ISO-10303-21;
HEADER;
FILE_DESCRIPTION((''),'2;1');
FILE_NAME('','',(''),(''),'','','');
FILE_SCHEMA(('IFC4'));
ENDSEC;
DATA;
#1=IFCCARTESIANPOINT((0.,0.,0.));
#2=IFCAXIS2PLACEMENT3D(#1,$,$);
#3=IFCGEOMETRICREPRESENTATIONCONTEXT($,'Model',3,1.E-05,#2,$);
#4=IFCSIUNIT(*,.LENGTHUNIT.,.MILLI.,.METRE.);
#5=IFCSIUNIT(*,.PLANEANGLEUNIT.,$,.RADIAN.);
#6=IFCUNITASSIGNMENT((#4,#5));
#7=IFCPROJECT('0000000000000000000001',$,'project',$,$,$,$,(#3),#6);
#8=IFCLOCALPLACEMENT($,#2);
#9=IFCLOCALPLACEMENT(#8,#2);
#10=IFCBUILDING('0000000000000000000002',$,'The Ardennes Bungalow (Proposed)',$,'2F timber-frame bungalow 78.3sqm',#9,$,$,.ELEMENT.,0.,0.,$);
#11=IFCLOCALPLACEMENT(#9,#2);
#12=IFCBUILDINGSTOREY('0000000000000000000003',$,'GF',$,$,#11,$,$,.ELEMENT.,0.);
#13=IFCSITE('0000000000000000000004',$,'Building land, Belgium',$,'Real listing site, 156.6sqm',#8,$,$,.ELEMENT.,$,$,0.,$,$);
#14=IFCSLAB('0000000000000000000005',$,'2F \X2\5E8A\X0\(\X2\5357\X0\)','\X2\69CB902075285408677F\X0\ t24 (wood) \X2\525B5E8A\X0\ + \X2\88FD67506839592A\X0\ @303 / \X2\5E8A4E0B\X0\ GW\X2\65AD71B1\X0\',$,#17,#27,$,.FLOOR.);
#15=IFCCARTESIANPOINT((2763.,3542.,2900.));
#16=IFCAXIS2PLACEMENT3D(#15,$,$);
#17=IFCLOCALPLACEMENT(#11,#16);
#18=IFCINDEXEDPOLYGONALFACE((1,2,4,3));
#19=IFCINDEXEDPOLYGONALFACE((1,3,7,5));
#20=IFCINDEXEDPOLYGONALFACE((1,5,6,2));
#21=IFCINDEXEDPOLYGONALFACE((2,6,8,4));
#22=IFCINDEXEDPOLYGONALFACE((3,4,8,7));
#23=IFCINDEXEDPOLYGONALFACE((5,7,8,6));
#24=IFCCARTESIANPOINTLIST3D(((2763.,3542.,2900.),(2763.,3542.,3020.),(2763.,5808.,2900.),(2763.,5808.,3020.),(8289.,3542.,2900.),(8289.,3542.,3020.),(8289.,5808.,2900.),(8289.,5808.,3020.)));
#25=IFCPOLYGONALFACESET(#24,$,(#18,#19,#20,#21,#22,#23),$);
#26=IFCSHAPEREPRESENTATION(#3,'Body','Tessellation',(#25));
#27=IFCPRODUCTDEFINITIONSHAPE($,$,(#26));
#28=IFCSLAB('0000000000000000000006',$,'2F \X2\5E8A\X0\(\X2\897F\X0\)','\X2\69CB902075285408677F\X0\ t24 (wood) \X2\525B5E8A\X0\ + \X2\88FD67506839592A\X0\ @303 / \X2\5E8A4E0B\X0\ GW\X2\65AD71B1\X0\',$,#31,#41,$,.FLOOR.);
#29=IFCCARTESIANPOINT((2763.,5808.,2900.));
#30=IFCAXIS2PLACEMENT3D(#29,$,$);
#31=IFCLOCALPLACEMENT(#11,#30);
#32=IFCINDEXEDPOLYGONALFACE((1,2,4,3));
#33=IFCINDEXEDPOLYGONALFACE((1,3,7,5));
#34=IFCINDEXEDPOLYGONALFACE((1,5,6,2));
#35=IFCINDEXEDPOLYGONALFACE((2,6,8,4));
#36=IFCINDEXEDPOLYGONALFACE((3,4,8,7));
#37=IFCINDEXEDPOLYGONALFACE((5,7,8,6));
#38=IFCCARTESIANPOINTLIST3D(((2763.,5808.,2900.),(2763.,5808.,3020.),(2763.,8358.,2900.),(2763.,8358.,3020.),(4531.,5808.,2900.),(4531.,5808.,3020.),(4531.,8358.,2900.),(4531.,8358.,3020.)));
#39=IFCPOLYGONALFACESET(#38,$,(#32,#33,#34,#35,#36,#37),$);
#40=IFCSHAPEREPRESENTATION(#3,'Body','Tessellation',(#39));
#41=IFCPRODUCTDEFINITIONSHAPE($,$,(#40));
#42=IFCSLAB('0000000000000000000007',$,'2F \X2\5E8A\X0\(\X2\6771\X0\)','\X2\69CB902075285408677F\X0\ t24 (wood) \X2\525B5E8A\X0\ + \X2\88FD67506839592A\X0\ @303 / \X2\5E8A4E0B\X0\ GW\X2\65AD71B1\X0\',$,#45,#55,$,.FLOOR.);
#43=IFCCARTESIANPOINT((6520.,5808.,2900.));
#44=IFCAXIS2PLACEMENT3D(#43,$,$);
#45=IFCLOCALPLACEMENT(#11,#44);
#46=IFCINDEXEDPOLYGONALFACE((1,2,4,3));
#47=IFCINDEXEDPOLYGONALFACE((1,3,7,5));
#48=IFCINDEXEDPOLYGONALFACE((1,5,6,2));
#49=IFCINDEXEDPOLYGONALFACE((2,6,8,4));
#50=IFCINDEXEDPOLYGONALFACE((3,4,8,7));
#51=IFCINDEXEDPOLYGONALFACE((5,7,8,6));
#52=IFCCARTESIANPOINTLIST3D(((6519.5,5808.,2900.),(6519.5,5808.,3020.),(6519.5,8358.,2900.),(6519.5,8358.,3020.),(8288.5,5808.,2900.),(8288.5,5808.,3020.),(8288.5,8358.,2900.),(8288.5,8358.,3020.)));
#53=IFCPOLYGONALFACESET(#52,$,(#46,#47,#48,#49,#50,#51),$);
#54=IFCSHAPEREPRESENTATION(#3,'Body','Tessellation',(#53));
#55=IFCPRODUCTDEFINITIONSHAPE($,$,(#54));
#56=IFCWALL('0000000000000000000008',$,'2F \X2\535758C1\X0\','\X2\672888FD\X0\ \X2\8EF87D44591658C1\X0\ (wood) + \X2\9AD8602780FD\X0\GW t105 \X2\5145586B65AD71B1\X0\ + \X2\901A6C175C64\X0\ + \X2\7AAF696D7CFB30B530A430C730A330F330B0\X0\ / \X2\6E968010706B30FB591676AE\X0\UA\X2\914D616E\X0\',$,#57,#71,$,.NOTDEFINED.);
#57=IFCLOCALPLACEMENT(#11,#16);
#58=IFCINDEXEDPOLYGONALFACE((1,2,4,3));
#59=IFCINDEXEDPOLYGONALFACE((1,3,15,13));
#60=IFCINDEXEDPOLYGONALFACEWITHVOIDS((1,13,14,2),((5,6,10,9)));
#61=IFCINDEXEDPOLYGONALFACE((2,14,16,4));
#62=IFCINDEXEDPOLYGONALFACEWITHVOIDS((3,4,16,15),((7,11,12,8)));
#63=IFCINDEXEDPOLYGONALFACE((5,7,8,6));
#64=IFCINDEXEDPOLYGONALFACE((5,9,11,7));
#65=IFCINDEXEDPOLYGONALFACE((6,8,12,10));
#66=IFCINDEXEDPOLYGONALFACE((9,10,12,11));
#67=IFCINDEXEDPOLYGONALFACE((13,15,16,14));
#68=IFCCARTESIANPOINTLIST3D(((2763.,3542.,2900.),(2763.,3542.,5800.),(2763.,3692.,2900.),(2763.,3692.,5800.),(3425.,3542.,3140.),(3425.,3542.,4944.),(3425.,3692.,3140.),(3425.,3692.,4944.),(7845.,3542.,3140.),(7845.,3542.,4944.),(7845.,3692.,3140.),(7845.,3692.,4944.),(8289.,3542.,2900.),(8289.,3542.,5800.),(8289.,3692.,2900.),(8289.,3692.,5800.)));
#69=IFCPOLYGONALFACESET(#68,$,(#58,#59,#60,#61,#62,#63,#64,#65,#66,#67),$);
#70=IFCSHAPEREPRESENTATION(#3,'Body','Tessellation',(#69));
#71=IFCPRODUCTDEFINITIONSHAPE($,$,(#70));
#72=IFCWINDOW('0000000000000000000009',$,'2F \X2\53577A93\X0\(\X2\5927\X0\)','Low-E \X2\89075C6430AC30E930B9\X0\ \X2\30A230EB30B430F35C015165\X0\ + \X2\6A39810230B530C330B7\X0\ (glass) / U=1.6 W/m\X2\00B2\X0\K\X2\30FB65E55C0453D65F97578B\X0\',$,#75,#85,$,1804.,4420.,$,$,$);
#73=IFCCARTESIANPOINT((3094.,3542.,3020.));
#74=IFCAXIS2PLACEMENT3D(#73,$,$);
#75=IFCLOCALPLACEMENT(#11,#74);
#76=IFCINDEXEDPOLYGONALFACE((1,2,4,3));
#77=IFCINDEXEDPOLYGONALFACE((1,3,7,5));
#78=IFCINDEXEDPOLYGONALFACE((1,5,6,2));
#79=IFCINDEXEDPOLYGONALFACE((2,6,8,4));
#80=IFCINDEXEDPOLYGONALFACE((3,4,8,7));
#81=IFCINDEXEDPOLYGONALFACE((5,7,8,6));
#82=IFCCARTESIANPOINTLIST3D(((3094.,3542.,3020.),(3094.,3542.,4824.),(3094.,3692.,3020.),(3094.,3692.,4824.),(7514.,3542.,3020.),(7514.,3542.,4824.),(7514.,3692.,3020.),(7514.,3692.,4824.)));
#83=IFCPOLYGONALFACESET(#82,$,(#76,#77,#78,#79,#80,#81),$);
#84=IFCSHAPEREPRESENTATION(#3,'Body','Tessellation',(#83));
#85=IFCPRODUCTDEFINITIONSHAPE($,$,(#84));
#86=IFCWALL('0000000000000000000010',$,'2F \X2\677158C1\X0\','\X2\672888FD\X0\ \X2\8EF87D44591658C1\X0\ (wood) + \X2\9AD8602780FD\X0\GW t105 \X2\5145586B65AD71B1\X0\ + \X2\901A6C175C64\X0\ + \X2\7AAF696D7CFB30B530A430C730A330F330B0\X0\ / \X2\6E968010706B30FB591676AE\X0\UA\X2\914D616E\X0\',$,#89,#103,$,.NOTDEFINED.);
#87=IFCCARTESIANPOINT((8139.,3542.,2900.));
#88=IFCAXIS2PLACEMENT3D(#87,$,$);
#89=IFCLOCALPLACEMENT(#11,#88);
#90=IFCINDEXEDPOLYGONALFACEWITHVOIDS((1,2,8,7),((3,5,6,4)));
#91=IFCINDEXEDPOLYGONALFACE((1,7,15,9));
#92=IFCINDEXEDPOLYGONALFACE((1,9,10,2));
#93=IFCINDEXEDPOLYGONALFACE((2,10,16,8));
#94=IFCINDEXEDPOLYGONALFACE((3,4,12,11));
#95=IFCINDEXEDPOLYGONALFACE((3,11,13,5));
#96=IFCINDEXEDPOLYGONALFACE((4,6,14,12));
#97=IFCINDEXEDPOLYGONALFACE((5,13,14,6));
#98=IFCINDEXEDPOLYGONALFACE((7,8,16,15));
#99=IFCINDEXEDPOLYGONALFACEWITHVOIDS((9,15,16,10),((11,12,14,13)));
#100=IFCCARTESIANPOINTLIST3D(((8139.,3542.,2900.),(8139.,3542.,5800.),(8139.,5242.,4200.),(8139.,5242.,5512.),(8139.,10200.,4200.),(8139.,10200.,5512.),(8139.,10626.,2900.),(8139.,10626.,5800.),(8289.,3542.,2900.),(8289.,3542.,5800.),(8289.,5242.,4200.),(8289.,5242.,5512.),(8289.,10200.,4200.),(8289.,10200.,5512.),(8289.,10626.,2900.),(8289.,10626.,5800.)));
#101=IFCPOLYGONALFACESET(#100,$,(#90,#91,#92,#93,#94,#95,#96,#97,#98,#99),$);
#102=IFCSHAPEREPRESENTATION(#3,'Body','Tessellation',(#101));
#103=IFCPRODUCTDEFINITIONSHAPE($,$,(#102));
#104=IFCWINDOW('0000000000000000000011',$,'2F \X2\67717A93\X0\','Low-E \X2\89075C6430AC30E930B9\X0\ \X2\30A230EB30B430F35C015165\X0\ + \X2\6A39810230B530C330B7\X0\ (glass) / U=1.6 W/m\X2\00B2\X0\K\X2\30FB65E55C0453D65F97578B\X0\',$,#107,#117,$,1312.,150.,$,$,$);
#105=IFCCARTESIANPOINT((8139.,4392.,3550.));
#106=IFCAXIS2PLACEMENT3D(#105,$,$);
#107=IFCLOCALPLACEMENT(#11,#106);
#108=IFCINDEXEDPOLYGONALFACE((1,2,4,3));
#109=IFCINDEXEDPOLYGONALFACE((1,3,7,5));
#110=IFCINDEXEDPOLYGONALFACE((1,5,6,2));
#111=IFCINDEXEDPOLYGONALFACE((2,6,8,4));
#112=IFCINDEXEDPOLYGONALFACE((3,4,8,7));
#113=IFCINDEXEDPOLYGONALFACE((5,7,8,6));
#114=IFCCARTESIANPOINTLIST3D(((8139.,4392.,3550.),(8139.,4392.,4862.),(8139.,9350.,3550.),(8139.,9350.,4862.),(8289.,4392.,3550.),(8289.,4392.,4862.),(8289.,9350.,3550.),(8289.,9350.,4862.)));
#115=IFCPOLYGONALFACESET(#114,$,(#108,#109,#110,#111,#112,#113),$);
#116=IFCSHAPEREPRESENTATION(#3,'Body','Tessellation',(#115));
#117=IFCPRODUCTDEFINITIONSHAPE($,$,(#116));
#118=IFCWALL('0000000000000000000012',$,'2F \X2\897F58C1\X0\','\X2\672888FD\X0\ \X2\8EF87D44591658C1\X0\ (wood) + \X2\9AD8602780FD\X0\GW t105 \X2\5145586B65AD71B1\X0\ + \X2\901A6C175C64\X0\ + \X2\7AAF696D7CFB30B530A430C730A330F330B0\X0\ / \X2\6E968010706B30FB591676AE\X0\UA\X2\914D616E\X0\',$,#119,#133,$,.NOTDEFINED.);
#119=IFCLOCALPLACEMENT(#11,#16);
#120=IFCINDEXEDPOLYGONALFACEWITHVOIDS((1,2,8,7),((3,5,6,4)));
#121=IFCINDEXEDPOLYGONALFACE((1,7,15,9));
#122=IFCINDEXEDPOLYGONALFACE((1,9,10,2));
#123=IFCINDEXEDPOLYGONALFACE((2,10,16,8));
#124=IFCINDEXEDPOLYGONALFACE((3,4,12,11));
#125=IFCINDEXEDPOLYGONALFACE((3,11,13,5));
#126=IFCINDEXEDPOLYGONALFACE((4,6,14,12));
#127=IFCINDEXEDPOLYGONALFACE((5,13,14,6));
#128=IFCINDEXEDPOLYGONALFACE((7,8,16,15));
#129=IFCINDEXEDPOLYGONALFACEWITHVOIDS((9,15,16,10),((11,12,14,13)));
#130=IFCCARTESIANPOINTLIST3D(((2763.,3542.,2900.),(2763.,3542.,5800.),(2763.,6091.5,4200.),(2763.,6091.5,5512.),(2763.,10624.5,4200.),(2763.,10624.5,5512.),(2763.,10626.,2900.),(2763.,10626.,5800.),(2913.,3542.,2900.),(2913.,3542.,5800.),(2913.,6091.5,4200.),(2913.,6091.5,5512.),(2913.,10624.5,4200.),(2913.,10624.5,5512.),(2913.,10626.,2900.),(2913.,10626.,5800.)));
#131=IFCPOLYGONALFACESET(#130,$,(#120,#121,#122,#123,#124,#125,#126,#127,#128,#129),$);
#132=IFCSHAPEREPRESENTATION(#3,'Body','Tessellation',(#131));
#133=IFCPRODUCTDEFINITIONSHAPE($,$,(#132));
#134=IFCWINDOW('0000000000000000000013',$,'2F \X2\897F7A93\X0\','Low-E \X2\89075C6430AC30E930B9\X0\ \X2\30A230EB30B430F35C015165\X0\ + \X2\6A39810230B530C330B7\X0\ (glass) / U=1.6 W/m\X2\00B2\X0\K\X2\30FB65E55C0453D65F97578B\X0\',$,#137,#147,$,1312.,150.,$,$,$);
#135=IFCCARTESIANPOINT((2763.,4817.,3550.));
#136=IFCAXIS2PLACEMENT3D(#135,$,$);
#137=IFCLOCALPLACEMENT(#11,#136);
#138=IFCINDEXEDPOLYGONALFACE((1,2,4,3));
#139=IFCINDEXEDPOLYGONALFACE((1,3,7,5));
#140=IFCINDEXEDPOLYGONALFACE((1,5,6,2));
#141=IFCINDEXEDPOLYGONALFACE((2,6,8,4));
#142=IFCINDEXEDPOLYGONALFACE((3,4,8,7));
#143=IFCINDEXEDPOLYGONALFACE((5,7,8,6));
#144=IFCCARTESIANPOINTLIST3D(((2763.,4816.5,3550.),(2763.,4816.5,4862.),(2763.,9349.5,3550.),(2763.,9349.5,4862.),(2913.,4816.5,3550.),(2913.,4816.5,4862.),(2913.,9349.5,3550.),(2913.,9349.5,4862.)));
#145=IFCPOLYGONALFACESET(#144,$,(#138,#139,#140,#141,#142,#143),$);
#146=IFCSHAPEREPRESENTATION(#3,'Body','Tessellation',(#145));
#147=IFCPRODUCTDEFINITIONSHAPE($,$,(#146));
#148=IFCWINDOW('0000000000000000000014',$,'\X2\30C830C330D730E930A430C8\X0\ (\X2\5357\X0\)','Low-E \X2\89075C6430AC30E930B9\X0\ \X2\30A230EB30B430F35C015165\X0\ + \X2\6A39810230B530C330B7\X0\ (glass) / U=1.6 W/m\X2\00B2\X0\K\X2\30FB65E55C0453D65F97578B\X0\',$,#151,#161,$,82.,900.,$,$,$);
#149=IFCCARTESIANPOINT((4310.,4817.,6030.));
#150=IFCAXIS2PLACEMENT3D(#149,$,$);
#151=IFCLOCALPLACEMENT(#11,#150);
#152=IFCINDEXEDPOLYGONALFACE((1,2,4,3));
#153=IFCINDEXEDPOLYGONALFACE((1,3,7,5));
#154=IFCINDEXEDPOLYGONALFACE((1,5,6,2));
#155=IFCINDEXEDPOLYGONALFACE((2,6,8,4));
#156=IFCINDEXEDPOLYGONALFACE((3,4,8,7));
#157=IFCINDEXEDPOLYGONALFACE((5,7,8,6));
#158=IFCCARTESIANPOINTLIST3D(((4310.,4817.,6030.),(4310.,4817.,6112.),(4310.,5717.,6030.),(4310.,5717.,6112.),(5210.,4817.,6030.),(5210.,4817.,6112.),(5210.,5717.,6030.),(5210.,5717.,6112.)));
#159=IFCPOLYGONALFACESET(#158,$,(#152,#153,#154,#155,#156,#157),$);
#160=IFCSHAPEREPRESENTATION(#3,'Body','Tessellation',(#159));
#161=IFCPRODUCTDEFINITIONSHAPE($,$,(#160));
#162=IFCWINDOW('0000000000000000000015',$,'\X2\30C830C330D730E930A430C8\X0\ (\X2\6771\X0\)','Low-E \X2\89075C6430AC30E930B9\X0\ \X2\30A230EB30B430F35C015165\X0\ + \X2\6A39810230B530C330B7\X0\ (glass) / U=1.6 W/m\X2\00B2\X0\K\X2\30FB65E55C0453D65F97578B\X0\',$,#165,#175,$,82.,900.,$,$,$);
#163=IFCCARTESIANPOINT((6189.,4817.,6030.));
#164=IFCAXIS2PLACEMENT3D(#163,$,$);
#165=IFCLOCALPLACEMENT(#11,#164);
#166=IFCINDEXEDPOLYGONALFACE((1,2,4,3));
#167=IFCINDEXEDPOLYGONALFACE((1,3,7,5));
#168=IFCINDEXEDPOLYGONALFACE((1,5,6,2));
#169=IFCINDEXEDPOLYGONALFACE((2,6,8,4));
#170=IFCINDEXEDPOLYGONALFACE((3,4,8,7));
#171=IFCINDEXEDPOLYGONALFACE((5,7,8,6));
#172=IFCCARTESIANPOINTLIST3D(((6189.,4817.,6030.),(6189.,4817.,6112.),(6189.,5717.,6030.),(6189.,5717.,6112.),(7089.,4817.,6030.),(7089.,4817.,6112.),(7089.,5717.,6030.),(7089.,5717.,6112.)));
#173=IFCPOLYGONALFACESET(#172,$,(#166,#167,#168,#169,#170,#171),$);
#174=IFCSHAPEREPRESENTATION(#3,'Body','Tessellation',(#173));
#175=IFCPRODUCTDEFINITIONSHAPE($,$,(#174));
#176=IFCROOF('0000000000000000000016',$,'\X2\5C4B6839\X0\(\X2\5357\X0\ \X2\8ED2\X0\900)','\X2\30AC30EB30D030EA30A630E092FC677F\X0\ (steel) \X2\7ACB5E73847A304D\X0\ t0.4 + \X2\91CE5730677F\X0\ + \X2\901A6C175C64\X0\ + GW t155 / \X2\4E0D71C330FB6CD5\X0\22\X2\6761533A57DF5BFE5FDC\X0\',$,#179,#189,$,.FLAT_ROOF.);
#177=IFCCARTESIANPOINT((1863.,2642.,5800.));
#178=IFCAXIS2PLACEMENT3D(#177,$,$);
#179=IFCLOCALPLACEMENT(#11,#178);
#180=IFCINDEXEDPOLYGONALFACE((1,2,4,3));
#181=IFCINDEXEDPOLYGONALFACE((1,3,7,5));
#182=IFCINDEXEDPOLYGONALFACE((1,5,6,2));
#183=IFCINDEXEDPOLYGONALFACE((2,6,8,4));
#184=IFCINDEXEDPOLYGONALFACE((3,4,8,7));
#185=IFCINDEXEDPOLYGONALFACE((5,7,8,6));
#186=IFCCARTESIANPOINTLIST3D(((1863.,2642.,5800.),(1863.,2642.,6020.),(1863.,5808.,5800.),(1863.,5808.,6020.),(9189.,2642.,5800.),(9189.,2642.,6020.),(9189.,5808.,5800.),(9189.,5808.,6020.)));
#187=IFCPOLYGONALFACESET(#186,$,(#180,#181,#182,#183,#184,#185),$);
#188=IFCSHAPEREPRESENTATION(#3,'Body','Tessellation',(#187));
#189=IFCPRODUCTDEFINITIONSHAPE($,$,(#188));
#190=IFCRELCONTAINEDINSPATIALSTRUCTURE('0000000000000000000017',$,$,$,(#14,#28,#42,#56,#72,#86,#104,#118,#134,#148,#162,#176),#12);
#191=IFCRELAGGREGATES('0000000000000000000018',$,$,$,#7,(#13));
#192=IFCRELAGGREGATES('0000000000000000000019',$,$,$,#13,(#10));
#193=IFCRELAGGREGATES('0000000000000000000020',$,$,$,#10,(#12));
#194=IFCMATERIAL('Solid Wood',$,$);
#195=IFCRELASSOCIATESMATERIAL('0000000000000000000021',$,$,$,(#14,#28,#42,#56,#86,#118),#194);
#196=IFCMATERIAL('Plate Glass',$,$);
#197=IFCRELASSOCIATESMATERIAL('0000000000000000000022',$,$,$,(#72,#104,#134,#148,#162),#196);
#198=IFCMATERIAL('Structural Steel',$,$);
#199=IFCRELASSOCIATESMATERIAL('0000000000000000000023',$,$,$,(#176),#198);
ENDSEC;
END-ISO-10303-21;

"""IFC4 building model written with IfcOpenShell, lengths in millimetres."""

from ifc_helpers import new_model, si_unit, frame, frame_2d, origin, place, context, project, spatial, rectangle, extrude, material, element, fill, save


model = new_model("IFC4")

# Units and contexts
model_context = context("Model", 3, precision=1e-05, world=origin())
ifc_project = project(units=[si_unit("LENGTHUNIT", "METRE", prefix="MILLI"), si_unit("PLANEANGLEUNIT", "RADIAN")], contexts=[model_context])

# Site, building, storey
site_placement = place(None, origin())
site = spatial("IfcSite", under=ifc_project, at=site_placement, Name="Building land, Belgium", ObjectType="Real listing site, 156.6sqm", CompositionType="ELEMENT", RefElevation=0.0)
building_placement = place(site_placement, origin())
building = spatial("IfcBuilding", under=site, at=building_placement, Name="The Ardennes Bungalow (Proposed)", ObjectType="2F timber-frame bungalow 78.3sqm", CompositionType="ELEMENT", ElevationOfRefHeight=0.0, ElevationOfTerrain=0.0)
storey_placement = place(building_placement, origin())
storey = spatial("IfcBuildingStorey", under=building, at=storey_placement, Name="GF", CompositionType="ELEMENT", Elevation=0.0)

# Slabs
ifc_material_1 = material(Name="Solid Wood")
slab_1_placement = place(storey_placement, frame((2763.0, 3542.0, 2900.0)))
element("IfcSlab", 1, at=slab_1_placement, inside=storey, material=ifc_material_1, Name="2F 床(南)", Description="構造用合板 t24 (wood) 剛床 + 製材根太 @303 / 床下 GW断熱", PredefinedType="FLOOR", context=model_context, shape_type="SweptSolid", body=[
    extrude(rectangle(XDim=5526.0, YDim=2266.0, at=frame_2d((2763.0, 1133.0))), frame((2763.0, 3542.0, 2900.0)), (0.0, 0.0, 1.0), 120.0),
])
slab_2_placement = place(storey_placement, frame((2763.0, 5808.0, 2900.0)))
element("IfcSlab", 2, at=slab_2_placement, inside=storey, material=ifc_material_1, Name="2F 床(西)", Description="構造用合板 t24 (wood) 剛床 + 製材根太 @303 / 床下 GW断熱", PredefinedType="FLOOR", context=model_context, shape_type="SweptSolid", body=[
    extrude(rectangle(XDim=1768.0, YDim=2550.0, at=frame_2d((884.0, 1275.0))), frame((2763.0, 5808.0, 2900.0)), (0.0, 0.0, 1.0), 120.0),
])
slab_3_placement = place(storey_placement, frame((6520.0, 5808.0, 2900.0)))
element("IfcSlab", 3, at=slab_3_placement, inside=storey, material=ifc_material_1, Name="2F 床(東)", Description="構造用合板 t24 (wood) 剛床 + 製材根太 @303 / 床下 GW断熱", PredefinedType="FLOOR", context=model_context, shape_type="SweptSolid", body=[
    extrude(rectangle(XDim=1769.0, YDim=2550.0, at=frame_2d((884.0, 1275.0))), frame((6520.0, 5808.0, 2900.0)), (0.0, 0.0, 1.0), 120.0),
])

# Walls, openings, windows
wall_1_placement = place(storey_placement, frame((2763.0, 3542.0, 2900.0)))
wall_1 = element("IfcWall", 4, at=wall_1_placement, inside=storey, material=ifc_material_1, Name="2F 南壁", Description="木製 軸組外壁 (wood) + 高性能GW t105 充填断熱 + 通気層 + 窯業系サイディング / 準耐火・外皮UA配慮", PredefinedType="NOTDEFINED", context=model_context, shape_type="SweptSolid", body=[
    extrude(rectangle(XDim=5526.0, YDim=150.0, at=frame_2d((2763.0, 75.0))), frame((2763.0, 3542.0, 2900.0)), (0.0, 0.0, 1.0), 2900.0),
])
opening_1_placement = place(storey_placement, frame((3094.0, 3542.0, 3020.0)))
opening_1 = element("IfcOpeningElement", 5, at=opening_1_placement, cuts=wall_1, PredefinedType="NOTDEFINED", context=model_context, shape_type="SweptSolid", body=[
    extrude(rectangle(XDim=4420.0, YDim=150.0, at=frame_2d((2210.0, 75.0))), frame((3094.0, 3542.0, 3020.0)), (0.0, 0.0, 1.0), 1804.0),
])
ifc_material_2 = material(Name="Plate Glass")
window_1_placement = place(storey_placement, frame((3094.0, 3542.0, 3020.0)))
window_1 = element("IfcWindow", 6, at=window_1_placement, inside=storey, material=ifc_material_2, Name="2F 南窓(大)", Description="Low-E 複層ガラス アルゴン封入 + 樹脂サッシ (glass) / U=1.6 W/m²K・日射取得型", OverallHeight=1804.0, OverallWidth=4420.0, context=model_context, shape_type="SweptSolid", body=[
    extrude(rectangle(XDim=4420.0, YDim=150.0, at=frame_2d((2210.0, 75.0))), frame((3094.0, 3542.0, 3020.0)), (0.0, 0.0, 1.0), 1804.0),
])
fill(opening_1, window_1)
wall_2_placement = place(storey_placement, frame((8139.0, 3542.0, 2900.0)))
wall_2 = element("IfcWall", 7, at=wall_2_placement, inside=storey, material=ifc_material_1, Name="2F 東壁", Description="木製 軸組外壁 (wood) + 高性能GW t105 充填断熱 + 通気層 + 窯業系サイディング / 準耐火・外皮UA配慮", PredefinedType="NOTDEFINED", context=model_context, shape_type="SweptSolid", body=[
    extrude(rectangle(XDim=150.0, YDim=7084.0, at=frame_2d((75.0, 3542.0))), frame((8139.0, 3542.0, 2900.0)), (0.0, 0.0, 1.0), 2900.0),
])
opening_2_placement = place(storey_placement, frame((8139.0, 4392.0, 3550.0)))
opening_2 = element("IfcOpeningElement", 8, at=opening_2_placement, cuts=wall_2, PredefinedType="NOTDEFINED", context=model_context, shape_type="SweptSolid", body=[
    extrude(rectangle(XDim=150.0, YDim=4958.0, at=frame_2d((75.0, 2479.0))), frame((8139.0, 4392.0, 3550.0)), (0.0, 0.0, 1.0), 1312.0),
])
window_2_placement = place(storey_placement, frame((8139.0, 4392.0, 3550.0)))
window_2 = element("IfcWindow", 9, at=window_2_placement, inside=storey, material=ifc_material_2, Name="2F 東窓", Description="Low-E 複層ガラス アルゴン封入 + 樹脂サッシ (glass) / U=1.6 W/m²K・日射取得型", OverallHeight=1312.0, OverallWidth=150.0, context=model_context, shape_type="SweptSolid", body=[
    extrude(rectangle(XDim=150.0, YDim=4958.0, at=frame_2d((75.0, 2479.0))), frame((8139.0, 4392.0, 3550.0)), (0.0, 0.0, 1.0), 1312.0),
])
fill(opening_2, window_2)
wall_3_placement = place(storey_placement, frame((2763.0, 3542.0, 2900.0)))
wall_3 = element("IfcWall", 10, at=wall_3_placement, inside=storey, material=ifc_material_1, Name="2F 西壁", Description="木製 軸組外壁 (wood) + 高性能GW t105 充填断熱 + 通気層 + 窯業系サイディング / 準耐火・外皮UA配慮", PredefinedType="NOTDEFINED", context=model_context, shape_type="SweptSolid", body=[
    extrude(rectangle(XDim=150.0, YDim=7084.0, at=frame_2d((75.0, 3542.0))), frame((2763.0, 3542.0, 2900.0)), (0.0, 0.0, 1.0), 2900.0),
])
opening_3_placement = place(storey_placement, frame((2763.0, 4817.0, 3550.0)))
opening_3 = element("IfcOpeningElement", 11, at=opening_3_placement, cuts=wall_3, PredefinedType="NOTDEFINED", context=model_context, shape_type="SweptSolid", body=[
    extrude(rectangle(XDim=150.0, YDim=4533.0, at=frame_2d((75.0, 2266.0))), frame((2763.0, 4817.0, 3550.0)), (0.0, 0.0, 1.0), 1312.0),
])
window_3_placement = place(storey_placement, frame((2763.0, 4817.0, 3550.0)))
window_3 = element("IfcWindow", 12, at=window_3_placement, inside=storey, material=ifc_material_2, Name="2F 西窓", Description="Low-E 複層ガラス アルゴン封入 + 樹脂サッシ (glass) / U=1.6 W/m²K・日射取得型", OverallHeight=1312.0, OverallWidth=150.0, context=model_context, shape_type="SweptSolid", body=[
    extrude(rectangle(XDim=150.0, YDim=4533.0, at=frame_2d((75.0, 2266.0))), frame((2763.0, 4817.0, 3550.0)), (0.0, 0.0, 1.0), 1312.0),
])
fill(opening_3, window_3)

# Windows
window_4_placement = place(storey_placement, frame((4310.0, 4817.0, 6030.0)))
element("IfcWindow", 13, at=window_4_placement, inside=storey, material=ifc_material_2, Name="トップライト (南)", Description="Low-E 複層ガラス アルゴン封入 + 樹脂サッシ (glass) / U=1.6 W/m²K・日射取得型", OverallHeight=82.0, OverallWidth=900.0, context=model_context, shape_type="SweptSolid", body=[
    extrude(rectangle(XDim=900.0, YDim=900.0, at=frame_2d((450.0, 450.0))), frame((4310.0, 4817.0, 6030.0)), (0.0, 0.0, 1.0), 82.0),
])
window_5_placement = place(storey_placement, frame((6189.0, 4817.0, 6030.0)))
element("IfcWindow", 14, at=window_5_placement, inside=storey, material=ifc_material_2, Name="トップライト (東)", Description="Low-E 複層ガラス アルゴン封入 + 樹脂サッシ (glass) / U=1.6 W/m²K・日射取得型", OverallHeight=82.0, OverallWidth=900.0, context=model_context, shape_type="SweptSolid", body=[
    extrude(rectangle(XDim=900.0, YDim=900.0, at=frame_2d((450.0, 450.0))), frame((6189.0, 4817.0, 6030.0)), (0.0, 0.0, 1.0), 82.0),
])

# Roof
ifc_material_3 = material(Name="Structural Steel")
roof_1_placement = place(storey_placement, frame((1863.0, 2642.0, 5800.0)))
element("IfcRoof", 15, at=roof_1_placement, inside=storey, material=ifc_material_3, Name="屋根(南 軒900)", Description="ガルバリウム鋼板 (steel) 立平葺き t0.4 + 野地板 + 通気層 + GW t155 / 不燃・法22条区域対応", PredefinedType="FLAT_ROOF", context=model_context, shape_type="SweptSolid", body=[
    extrude(rectangle(XDim=7326.0, YDim=3166.0, at=frame_2d((3663.0, 1583.0))), frame((1863.0, 2642.0, 5800.0)), (0.0, 0.0, 1.0), 220.0),
])

save(model, "model.ifc")
